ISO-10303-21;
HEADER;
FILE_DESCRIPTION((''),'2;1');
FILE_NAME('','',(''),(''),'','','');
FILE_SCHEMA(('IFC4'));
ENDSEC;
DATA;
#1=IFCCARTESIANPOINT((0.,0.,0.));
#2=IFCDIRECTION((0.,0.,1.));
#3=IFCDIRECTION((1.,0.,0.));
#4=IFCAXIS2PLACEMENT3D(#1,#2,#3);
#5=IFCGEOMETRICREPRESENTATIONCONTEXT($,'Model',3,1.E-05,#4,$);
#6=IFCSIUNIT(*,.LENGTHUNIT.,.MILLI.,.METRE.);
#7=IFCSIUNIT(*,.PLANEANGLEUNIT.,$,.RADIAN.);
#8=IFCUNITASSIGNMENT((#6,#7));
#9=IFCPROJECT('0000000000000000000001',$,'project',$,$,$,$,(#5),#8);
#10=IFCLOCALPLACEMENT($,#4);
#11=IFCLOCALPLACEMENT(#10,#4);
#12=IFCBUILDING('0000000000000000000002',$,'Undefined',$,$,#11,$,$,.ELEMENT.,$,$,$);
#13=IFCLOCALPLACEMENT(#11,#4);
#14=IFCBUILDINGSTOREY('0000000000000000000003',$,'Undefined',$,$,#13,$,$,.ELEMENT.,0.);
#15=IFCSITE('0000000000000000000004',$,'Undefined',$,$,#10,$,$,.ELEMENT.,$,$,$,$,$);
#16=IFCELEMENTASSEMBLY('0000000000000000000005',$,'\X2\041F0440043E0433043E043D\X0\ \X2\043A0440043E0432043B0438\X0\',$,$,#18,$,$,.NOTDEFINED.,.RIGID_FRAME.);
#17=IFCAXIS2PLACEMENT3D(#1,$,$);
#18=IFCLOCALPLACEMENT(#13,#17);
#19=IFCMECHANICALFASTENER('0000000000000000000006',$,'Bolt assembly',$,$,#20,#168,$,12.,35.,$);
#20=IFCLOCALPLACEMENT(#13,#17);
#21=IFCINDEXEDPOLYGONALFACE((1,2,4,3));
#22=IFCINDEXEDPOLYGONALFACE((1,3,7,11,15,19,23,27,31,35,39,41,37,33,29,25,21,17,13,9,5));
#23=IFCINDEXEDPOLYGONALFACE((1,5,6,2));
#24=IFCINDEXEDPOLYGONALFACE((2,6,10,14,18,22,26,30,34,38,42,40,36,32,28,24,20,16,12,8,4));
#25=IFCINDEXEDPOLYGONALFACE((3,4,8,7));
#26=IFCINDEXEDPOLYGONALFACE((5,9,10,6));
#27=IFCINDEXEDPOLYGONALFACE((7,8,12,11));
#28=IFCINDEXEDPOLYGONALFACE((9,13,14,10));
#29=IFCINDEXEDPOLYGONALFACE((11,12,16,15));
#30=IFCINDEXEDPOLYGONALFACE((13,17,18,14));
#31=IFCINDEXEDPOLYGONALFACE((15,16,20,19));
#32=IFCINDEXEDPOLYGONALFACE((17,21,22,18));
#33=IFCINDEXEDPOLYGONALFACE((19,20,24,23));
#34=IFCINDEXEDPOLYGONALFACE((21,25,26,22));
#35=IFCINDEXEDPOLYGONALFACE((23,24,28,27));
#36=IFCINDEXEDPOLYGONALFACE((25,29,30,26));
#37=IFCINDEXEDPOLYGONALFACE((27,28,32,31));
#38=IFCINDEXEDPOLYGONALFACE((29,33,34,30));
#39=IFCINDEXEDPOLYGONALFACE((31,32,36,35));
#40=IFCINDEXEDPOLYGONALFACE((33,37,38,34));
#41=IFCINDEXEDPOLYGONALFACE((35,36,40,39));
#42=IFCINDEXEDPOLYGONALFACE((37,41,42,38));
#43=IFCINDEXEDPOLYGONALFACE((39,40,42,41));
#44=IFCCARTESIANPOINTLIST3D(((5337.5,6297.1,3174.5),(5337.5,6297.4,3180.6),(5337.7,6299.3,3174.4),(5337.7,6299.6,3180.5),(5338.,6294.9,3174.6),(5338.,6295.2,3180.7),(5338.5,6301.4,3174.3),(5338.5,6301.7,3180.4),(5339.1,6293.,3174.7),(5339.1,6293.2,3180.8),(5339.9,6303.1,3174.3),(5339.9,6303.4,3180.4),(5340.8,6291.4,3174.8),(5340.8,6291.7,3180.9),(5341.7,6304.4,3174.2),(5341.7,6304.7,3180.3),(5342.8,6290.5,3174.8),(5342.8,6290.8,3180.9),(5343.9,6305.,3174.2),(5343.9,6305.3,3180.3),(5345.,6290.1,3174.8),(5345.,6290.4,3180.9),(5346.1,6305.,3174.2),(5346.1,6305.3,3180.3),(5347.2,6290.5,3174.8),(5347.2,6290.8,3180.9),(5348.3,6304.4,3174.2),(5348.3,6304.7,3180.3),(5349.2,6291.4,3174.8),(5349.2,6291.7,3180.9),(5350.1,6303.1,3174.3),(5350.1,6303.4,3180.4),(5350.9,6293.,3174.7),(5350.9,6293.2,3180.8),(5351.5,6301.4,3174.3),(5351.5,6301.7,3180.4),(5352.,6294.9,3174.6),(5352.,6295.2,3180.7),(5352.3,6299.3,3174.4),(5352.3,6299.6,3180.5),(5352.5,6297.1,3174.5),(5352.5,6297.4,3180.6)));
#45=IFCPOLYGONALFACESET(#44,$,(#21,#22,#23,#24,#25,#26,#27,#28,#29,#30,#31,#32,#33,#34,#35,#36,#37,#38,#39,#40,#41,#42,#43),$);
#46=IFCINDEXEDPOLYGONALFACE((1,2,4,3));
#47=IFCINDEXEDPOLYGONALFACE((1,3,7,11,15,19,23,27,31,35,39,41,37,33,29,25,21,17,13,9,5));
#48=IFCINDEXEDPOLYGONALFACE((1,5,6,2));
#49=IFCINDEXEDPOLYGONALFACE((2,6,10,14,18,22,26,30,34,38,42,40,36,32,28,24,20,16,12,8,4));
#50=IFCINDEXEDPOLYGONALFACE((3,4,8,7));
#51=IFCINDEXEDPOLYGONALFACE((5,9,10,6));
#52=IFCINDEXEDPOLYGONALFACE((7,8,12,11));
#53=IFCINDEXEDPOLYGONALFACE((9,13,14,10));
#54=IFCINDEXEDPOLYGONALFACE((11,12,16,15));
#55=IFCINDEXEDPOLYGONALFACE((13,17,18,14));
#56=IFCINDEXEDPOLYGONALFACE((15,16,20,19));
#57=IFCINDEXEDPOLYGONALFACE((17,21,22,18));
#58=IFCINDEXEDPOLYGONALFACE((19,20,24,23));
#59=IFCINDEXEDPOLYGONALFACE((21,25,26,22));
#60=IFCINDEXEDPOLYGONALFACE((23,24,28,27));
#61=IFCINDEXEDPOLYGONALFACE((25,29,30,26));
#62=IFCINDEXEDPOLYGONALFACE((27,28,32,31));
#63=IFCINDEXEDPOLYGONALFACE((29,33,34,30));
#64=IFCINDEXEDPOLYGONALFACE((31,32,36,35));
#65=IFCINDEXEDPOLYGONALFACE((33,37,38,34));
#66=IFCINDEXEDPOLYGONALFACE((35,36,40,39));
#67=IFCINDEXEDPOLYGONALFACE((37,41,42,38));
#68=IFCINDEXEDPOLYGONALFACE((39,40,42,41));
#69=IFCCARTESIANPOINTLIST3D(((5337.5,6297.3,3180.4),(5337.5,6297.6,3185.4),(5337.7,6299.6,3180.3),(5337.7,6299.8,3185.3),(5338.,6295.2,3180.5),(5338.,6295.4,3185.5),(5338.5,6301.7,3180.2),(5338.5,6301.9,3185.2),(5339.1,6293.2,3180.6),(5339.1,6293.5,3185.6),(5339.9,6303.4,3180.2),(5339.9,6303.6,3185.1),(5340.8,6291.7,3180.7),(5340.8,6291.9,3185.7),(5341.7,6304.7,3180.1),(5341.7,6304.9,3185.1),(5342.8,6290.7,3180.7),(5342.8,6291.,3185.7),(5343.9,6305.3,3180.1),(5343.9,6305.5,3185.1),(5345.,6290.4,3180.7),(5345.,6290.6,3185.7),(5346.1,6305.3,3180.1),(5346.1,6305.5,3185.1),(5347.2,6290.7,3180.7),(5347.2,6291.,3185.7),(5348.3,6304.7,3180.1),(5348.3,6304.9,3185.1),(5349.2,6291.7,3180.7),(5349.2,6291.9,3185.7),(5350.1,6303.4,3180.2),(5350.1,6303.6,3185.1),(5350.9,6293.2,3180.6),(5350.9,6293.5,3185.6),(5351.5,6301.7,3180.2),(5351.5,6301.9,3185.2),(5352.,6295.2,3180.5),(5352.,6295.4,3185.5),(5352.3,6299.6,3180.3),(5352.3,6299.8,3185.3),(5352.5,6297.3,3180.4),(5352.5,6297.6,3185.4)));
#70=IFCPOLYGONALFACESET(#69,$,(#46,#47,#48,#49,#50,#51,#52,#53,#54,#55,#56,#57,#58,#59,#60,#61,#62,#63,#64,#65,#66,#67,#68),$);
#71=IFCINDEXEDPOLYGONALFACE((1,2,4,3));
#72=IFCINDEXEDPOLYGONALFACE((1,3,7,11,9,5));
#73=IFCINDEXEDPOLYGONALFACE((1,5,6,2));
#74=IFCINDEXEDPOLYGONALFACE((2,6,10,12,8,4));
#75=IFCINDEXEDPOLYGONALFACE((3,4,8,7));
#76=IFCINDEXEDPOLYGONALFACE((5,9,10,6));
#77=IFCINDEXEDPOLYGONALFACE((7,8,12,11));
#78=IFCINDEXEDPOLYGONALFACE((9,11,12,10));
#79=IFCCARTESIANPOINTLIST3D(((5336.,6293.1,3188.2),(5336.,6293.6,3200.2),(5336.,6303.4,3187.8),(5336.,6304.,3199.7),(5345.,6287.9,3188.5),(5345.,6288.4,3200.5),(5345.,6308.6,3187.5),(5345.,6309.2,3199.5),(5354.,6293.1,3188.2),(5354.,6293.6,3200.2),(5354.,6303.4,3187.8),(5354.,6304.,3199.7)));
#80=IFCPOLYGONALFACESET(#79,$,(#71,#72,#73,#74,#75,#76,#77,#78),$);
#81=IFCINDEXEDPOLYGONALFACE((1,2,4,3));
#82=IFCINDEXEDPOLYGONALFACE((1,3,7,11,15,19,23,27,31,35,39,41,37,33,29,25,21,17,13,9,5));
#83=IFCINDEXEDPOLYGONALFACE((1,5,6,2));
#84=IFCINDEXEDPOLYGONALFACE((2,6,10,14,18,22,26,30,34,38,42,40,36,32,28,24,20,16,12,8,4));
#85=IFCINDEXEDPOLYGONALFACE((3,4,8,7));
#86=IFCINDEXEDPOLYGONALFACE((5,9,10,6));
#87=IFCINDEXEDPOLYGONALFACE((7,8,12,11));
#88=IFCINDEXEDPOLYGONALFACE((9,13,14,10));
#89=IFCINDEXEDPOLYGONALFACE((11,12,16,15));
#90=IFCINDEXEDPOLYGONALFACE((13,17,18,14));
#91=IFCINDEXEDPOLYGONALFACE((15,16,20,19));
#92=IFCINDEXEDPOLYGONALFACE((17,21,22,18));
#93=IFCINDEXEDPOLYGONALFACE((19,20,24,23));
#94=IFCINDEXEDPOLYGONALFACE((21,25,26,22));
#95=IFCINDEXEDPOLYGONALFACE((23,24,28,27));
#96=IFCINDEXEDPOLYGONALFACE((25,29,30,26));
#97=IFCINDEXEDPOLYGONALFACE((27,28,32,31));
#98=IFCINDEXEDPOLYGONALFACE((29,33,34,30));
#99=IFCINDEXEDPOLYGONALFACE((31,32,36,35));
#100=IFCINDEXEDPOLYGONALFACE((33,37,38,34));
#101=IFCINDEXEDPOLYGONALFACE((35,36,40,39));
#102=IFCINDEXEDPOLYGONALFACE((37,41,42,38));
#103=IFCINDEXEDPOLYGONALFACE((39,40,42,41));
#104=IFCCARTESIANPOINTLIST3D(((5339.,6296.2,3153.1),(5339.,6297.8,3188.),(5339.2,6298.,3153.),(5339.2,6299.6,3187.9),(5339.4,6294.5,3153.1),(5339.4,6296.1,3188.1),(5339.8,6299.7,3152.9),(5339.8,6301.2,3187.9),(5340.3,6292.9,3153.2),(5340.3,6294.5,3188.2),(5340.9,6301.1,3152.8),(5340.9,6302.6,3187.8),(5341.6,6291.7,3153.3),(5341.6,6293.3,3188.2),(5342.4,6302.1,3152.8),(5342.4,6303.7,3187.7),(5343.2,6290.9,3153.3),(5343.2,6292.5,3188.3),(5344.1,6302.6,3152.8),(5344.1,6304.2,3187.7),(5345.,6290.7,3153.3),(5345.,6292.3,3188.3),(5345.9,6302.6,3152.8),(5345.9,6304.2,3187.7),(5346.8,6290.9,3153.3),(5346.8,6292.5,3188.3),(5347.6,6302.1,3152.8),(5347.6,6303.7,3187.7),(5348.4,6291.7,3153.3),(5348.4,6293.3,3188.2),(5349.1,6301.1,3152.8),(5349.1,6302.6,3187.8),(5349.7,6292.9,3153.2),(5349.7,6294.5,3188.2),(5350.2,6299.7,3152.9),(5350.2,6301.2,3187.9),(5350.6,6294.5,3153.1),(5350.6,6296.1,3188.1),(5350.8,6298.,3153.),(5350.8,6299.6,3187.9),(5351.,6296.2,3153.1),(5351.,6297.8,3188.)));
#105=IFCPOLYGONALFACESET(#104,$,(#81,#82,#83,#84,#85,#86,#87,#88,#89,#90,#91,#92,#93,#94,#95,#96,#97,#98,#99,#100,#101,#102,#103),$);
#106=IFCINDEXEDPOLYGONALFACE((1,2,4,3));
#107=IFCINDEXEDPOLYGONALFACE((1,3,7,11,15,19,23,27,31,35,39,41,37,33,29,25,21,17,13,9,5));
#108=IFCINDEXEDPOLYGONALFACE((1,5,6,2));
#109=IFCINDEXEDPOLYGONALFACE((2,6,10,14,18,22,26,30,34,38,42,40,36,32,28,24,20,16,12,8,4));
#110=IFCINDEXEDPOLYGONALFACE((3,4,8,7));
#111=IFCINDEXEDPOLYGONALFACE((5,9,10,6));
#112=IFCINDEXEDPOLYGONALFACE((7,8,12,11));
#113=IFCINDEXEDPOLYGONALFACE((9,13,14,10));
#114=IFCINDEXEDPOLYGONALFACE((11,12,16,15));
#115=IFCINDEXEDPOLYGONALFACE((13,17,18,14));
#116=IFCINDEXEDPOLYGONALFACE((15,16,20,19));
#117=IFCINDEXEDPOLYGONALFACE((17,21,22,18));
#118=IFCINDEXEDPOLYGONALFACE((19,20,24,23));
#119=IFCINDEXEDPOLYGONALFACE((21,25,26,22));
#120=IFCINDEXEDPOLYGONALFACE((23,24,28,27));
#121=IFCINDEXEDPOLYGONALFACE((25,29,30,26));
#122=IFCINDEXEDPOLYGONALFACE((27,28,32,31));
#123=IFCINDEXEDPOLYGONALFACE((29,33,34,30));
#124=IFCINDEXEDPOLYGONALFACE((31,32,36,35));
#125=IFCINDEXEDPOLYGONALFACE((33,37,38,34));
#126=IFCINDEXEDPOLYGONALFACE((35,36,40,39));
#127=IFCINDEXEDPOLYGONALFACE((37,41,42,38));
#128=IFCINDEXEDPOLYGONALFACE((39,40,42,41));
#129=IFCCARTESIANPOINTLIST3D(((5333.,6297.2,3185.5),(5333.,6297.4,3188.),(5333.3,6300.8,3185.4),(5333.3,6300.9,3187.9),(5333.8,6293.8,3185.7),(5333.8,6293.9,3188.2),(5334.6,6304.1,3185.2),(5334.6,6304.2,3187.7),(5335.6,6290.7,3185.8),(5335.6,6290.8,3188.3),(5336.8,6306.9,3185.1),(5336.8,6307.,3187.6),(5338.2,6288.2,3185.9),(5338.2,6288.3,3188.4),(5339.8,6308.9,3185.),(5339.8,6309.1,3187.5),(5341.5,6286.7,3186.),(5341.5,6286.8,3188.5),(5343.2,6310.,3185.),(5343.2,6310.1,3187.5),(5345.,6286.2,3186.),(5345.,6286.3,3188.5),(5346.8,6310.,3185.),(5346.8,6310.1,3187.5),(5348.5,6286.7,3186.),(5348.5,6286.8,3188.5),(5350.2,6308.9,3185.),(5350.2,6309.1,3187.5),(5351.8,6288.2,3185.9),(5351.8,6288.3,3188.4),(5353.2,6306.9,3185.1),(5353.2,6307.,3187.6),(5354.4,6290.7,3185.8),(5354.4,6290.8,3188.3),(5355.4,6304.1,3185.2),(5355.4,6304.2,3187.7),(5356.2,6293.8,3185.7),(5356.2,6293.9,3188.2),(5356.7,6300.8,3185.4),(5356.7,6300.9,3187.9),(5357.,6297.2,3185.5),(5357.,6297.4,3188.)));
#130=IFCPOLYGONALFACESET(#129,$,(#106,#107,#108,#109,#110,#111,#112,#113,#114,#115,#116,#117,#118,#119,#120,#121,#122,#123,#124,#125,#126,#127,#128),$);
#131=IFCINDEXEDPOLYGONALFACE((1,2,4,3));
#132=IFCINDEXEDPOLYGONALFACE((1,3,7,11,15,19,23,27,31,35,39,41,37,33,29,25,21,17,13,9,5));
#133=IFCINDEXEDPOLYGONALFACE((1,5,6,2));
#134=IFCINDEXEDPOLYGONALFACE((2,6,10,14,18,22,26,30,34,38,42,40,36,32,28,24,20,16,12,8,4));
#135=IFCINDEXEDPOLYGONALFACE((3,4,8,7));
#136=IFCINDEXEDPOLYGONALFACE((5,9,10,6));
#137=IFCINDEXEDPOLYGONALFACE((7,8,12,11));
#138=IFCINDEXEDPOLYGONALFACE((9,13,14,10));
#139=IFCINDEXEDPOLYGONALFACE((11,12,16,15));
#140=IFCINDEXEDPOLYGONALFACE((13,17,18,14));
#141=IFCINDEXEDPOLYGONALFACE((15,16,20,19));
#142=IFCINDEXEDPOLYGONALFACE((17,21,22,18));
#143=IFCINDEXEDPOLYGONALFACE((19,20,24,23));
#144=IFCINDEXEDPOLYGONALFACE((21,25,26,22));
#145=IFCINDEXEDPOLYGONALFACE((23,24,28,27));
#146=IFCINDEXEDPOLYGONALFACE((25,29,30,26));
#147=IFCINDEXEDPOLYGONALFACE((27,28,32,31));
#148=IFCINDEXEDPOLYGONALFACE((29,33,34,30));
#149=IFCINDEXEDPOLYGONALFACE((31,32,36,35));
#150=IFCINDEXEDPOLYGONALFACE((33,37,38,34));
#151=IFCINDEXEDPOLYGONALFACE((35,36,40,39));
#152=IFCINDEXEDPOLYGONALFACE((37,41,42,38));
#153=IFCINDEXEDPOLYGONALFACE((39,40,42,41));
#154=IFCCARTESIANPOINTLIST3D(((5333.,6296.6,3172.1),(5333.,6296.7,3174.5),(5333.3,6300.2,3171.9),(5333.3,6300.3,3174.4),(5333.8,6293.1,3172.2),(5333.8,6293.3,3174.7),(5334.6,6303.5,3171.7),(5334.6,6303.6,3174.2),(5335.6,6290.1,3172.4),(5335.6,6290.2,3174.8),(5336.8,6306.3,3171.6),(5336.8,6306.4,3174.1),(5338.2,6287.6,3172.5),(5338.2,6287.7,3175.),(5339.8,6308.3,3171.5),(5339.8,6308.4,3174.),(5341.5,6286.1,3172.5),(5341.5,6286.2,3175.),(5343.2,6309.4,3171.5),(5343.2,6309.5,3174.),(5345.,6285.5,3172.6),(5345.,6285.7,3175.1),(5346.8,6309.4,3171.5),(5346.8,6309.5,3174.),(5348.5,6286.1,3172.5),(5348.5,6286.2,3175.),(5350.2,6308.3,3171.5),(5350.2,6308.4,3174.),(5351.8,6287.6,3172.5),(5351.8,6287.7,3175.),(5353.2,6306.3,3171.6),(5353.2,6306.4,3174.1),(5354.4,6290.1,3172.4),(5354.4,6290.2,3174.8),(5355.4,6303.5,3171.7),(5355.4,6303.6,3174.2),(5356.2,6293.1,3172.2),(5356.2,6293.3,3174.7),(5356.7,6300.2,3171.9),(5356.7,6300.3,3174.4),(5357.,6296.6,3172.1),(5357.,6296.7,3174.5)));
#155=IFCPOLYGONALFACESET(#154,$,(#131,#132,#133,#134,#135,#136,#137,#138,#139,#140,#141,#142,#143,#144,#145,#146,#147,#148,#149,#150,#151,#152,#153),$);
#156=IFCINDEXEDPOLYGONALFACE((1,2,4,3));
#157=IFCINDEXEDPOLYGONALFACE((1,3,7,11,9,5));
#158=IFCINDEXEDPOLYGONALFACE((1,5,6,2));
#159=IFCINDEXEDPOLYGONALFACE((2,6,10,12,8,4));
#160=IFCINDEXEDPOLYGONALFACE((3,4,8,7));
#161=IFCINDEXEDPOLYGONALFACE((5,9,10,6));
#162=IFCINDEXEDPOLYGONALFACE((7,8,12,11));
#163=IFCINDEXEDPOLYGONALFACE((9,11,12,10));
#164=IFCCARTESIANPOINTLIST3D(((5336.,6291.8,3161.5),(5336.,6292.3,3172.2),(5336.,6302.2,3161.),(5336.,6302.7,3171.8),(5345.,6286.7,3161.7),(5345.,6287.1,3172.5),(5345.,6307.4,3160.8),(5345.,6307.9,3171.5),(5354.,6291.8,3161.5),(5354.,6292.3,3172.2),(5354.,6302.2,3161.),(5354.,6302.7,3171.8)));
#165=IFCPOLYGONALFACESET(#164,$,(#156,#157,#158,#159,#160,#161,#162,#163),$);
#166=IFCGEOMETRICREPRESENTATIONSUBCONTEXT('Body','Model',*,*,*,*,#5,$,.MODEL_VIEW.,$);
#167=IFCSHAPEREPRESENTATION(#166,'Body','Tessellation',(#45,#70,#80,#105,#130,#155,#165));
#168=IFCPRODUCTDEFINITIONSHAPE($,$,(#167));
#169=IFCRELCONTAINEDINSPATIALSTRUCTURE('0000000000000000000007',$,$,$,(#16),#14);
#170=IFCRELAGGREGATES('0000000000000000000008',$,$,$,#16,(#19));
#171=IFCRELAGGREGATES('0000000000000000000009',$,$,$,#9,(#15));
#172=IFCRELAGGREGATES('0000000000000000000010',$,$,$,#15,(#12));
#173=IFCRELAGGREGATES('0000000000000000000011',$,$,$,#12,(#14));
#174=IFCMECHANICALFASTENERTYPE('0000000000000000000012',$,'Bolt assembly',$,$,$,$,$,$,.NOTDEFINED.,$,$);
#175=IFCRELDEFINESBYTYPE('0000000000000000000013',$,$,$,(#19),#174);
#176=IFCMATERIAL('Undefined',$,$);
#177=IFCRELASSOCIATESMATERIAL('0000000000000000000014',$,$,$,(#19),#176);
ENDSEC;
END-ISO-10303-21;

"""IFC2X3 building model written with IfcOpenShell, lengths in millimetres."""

from ifc_helpers import new_model, si_unit, frame, origin_with_axes, origin_2d_with_axis, place, context, subcontext, project, spatial, polyline, circle, outline, extrude, source, transform, mapped, material, type_object, element, aggregate, save


model = new_model("IFC2X3")

# Units and contexts
model_context = context("Model", 3, precision=1e-05, world=origin_with_axes())
body_context = subcontext(model_context, "Body", "Model", "MODEL_VIEW")
ifc_project = project(units=[si_unit("LENGTHUNIT", "METRE", prefix="MILLI"), si_unit("PLANEANGLEUNIT", "RADIAN")], contexts=[model_context])

# Site, building, storey
site_placement = place(None, origin_with_axes())
site = spatial("IfcSite", under=ifc_project, at=site_placement, Name="Undefined", CompositionType="ELEMENT")
building_placement = place(site_placement, origin_with_axes())
building = spatial("IfcBuilding", under=site, at=building_placement, Name="Undefined", CompositionType="ELEMENT")
storey_placement = place(building_placement, origin_with_axes())
storey = spatial("IfcBuildingStorey", under=building, at=storey_placement, Name="Undefined", CompositionType="ELEMENT", Elevation=0.0)

# Element assembly
assembly_1_placement = place(storey_placement, origin_with_axes())
assembly_1 = element("IfcElementAssembly", 1, at=assembly_1_placement, inside=storey, Name="Прогон кровли", AssemblyPlace="NOTDEFINED", PredefinedType="RIGID_FRAME")

# Mechanical fastener
ifc_material_1 = material(Name="Undefined")
mechanical_fastener_type = type_object("IfcMechanicalFastenerType", Name="Bolt assembly")
shared_shape_1 = source(origin_with_axes(), body_context, "Body", "SweptSolid", [
    extrude(circle(Radius=7.5, at=origin_2d_with_axis()), frame((0.0, -0.1, 0.0), z_axis=(0.0, 1.0, 0.0), x_axis=(1.0, 0.0, 0.0)), (0.0, 0.0, 1.0), 6.1),
    extrude(circle(Radius=7.5, at=origin_2d_with_axis()), frame((0.0, -4.9, 0.0), z_axis=(0.0, 1.0, 0.0), x_axis=(1.0, 0.0, 0.0)), (0.0, 0.0, 1.0), 5.0),
    extrude(outline(polyline([(10.4, 0.0), (5.2, 9.0), (-5.2, 9.0), (-10.4, 0.0), (-5.2, -9.0), (5.2, -9.0), (10.4, 0.0)])), frame((0.0, -19.5, 0.0), z_axis=(0.0, 1.0, 0.0), x_axis=(1.0, 0.0, 0.0)), (0.0, 0.0, 1.0), 12.0),
    extrude(circle(Radius=6.0, at=origin_2d_with_axis()), frame((0.0, -7.5, 0.0), z_axis=(0.0, 1.0, 0.0), x_axis=(1.0, 0.0, 0.0)), (0.0, 0.0, 1.0), 35.0),
    extrude(circle(Radius=12.0, at=origin_2d_with_axis()), frame((0.0, -7.5, 0.0), z_axis=(0.0, 1.0, 0.0), x_axis=(1.0, 0.0, 0.0)), (0.0, 0.0, 1.0), 2.5),
    extrude(circle(Radius=12.0, at=origin_2d_with_axis()), frame((0.0, 6.0, 0.0), z_axis=(0.0, 1.0, 0.0), x_axis=(1.0, 0.0, 0.0)), (0.0, 0.0, 1.0), 2.5),
    extrude(outline(polyline([(10.4, 0.0), (5.2, 9.0), (-5.2, 9.0), (-10.4, 0.0), (-5.2, -9.0), (5.2, -9.0), (10.4, 0.0)])), frame((0.0, 8.5, 0.0), z_axis=(0.0, 1.0, 0.0), x_axis=(1.0, 0.0, 0.0)), (0.0, 0.0, 1.0), 10.8),
])
mechanical_fastener_1_placement = place(assembly_1_placement, frame((5345.0, 6297.9, 3180.5), z_axis=(1.0, 0.0, 0.0), x_axis=(0.0, -0.998969, 0.045408)))
mechanical_fastener_1 = element("IfcMechanicalFastener", 2, at=mechanical_fastener_1_placement, type_object=mechanical_fastener_type, material=ifc_material_1, Name="Bolt assembly", NominalDiameter=12.0, NominalLength=35.0, context=body_context, shape_type="MappedRepresentation", body=[
    mapped(shared_shape_1, transform((0.0, 0.0, 0.0))),
])
aggregate(assembly_1, [mechanical_fastener_1])

save(model, "model.ifc")
